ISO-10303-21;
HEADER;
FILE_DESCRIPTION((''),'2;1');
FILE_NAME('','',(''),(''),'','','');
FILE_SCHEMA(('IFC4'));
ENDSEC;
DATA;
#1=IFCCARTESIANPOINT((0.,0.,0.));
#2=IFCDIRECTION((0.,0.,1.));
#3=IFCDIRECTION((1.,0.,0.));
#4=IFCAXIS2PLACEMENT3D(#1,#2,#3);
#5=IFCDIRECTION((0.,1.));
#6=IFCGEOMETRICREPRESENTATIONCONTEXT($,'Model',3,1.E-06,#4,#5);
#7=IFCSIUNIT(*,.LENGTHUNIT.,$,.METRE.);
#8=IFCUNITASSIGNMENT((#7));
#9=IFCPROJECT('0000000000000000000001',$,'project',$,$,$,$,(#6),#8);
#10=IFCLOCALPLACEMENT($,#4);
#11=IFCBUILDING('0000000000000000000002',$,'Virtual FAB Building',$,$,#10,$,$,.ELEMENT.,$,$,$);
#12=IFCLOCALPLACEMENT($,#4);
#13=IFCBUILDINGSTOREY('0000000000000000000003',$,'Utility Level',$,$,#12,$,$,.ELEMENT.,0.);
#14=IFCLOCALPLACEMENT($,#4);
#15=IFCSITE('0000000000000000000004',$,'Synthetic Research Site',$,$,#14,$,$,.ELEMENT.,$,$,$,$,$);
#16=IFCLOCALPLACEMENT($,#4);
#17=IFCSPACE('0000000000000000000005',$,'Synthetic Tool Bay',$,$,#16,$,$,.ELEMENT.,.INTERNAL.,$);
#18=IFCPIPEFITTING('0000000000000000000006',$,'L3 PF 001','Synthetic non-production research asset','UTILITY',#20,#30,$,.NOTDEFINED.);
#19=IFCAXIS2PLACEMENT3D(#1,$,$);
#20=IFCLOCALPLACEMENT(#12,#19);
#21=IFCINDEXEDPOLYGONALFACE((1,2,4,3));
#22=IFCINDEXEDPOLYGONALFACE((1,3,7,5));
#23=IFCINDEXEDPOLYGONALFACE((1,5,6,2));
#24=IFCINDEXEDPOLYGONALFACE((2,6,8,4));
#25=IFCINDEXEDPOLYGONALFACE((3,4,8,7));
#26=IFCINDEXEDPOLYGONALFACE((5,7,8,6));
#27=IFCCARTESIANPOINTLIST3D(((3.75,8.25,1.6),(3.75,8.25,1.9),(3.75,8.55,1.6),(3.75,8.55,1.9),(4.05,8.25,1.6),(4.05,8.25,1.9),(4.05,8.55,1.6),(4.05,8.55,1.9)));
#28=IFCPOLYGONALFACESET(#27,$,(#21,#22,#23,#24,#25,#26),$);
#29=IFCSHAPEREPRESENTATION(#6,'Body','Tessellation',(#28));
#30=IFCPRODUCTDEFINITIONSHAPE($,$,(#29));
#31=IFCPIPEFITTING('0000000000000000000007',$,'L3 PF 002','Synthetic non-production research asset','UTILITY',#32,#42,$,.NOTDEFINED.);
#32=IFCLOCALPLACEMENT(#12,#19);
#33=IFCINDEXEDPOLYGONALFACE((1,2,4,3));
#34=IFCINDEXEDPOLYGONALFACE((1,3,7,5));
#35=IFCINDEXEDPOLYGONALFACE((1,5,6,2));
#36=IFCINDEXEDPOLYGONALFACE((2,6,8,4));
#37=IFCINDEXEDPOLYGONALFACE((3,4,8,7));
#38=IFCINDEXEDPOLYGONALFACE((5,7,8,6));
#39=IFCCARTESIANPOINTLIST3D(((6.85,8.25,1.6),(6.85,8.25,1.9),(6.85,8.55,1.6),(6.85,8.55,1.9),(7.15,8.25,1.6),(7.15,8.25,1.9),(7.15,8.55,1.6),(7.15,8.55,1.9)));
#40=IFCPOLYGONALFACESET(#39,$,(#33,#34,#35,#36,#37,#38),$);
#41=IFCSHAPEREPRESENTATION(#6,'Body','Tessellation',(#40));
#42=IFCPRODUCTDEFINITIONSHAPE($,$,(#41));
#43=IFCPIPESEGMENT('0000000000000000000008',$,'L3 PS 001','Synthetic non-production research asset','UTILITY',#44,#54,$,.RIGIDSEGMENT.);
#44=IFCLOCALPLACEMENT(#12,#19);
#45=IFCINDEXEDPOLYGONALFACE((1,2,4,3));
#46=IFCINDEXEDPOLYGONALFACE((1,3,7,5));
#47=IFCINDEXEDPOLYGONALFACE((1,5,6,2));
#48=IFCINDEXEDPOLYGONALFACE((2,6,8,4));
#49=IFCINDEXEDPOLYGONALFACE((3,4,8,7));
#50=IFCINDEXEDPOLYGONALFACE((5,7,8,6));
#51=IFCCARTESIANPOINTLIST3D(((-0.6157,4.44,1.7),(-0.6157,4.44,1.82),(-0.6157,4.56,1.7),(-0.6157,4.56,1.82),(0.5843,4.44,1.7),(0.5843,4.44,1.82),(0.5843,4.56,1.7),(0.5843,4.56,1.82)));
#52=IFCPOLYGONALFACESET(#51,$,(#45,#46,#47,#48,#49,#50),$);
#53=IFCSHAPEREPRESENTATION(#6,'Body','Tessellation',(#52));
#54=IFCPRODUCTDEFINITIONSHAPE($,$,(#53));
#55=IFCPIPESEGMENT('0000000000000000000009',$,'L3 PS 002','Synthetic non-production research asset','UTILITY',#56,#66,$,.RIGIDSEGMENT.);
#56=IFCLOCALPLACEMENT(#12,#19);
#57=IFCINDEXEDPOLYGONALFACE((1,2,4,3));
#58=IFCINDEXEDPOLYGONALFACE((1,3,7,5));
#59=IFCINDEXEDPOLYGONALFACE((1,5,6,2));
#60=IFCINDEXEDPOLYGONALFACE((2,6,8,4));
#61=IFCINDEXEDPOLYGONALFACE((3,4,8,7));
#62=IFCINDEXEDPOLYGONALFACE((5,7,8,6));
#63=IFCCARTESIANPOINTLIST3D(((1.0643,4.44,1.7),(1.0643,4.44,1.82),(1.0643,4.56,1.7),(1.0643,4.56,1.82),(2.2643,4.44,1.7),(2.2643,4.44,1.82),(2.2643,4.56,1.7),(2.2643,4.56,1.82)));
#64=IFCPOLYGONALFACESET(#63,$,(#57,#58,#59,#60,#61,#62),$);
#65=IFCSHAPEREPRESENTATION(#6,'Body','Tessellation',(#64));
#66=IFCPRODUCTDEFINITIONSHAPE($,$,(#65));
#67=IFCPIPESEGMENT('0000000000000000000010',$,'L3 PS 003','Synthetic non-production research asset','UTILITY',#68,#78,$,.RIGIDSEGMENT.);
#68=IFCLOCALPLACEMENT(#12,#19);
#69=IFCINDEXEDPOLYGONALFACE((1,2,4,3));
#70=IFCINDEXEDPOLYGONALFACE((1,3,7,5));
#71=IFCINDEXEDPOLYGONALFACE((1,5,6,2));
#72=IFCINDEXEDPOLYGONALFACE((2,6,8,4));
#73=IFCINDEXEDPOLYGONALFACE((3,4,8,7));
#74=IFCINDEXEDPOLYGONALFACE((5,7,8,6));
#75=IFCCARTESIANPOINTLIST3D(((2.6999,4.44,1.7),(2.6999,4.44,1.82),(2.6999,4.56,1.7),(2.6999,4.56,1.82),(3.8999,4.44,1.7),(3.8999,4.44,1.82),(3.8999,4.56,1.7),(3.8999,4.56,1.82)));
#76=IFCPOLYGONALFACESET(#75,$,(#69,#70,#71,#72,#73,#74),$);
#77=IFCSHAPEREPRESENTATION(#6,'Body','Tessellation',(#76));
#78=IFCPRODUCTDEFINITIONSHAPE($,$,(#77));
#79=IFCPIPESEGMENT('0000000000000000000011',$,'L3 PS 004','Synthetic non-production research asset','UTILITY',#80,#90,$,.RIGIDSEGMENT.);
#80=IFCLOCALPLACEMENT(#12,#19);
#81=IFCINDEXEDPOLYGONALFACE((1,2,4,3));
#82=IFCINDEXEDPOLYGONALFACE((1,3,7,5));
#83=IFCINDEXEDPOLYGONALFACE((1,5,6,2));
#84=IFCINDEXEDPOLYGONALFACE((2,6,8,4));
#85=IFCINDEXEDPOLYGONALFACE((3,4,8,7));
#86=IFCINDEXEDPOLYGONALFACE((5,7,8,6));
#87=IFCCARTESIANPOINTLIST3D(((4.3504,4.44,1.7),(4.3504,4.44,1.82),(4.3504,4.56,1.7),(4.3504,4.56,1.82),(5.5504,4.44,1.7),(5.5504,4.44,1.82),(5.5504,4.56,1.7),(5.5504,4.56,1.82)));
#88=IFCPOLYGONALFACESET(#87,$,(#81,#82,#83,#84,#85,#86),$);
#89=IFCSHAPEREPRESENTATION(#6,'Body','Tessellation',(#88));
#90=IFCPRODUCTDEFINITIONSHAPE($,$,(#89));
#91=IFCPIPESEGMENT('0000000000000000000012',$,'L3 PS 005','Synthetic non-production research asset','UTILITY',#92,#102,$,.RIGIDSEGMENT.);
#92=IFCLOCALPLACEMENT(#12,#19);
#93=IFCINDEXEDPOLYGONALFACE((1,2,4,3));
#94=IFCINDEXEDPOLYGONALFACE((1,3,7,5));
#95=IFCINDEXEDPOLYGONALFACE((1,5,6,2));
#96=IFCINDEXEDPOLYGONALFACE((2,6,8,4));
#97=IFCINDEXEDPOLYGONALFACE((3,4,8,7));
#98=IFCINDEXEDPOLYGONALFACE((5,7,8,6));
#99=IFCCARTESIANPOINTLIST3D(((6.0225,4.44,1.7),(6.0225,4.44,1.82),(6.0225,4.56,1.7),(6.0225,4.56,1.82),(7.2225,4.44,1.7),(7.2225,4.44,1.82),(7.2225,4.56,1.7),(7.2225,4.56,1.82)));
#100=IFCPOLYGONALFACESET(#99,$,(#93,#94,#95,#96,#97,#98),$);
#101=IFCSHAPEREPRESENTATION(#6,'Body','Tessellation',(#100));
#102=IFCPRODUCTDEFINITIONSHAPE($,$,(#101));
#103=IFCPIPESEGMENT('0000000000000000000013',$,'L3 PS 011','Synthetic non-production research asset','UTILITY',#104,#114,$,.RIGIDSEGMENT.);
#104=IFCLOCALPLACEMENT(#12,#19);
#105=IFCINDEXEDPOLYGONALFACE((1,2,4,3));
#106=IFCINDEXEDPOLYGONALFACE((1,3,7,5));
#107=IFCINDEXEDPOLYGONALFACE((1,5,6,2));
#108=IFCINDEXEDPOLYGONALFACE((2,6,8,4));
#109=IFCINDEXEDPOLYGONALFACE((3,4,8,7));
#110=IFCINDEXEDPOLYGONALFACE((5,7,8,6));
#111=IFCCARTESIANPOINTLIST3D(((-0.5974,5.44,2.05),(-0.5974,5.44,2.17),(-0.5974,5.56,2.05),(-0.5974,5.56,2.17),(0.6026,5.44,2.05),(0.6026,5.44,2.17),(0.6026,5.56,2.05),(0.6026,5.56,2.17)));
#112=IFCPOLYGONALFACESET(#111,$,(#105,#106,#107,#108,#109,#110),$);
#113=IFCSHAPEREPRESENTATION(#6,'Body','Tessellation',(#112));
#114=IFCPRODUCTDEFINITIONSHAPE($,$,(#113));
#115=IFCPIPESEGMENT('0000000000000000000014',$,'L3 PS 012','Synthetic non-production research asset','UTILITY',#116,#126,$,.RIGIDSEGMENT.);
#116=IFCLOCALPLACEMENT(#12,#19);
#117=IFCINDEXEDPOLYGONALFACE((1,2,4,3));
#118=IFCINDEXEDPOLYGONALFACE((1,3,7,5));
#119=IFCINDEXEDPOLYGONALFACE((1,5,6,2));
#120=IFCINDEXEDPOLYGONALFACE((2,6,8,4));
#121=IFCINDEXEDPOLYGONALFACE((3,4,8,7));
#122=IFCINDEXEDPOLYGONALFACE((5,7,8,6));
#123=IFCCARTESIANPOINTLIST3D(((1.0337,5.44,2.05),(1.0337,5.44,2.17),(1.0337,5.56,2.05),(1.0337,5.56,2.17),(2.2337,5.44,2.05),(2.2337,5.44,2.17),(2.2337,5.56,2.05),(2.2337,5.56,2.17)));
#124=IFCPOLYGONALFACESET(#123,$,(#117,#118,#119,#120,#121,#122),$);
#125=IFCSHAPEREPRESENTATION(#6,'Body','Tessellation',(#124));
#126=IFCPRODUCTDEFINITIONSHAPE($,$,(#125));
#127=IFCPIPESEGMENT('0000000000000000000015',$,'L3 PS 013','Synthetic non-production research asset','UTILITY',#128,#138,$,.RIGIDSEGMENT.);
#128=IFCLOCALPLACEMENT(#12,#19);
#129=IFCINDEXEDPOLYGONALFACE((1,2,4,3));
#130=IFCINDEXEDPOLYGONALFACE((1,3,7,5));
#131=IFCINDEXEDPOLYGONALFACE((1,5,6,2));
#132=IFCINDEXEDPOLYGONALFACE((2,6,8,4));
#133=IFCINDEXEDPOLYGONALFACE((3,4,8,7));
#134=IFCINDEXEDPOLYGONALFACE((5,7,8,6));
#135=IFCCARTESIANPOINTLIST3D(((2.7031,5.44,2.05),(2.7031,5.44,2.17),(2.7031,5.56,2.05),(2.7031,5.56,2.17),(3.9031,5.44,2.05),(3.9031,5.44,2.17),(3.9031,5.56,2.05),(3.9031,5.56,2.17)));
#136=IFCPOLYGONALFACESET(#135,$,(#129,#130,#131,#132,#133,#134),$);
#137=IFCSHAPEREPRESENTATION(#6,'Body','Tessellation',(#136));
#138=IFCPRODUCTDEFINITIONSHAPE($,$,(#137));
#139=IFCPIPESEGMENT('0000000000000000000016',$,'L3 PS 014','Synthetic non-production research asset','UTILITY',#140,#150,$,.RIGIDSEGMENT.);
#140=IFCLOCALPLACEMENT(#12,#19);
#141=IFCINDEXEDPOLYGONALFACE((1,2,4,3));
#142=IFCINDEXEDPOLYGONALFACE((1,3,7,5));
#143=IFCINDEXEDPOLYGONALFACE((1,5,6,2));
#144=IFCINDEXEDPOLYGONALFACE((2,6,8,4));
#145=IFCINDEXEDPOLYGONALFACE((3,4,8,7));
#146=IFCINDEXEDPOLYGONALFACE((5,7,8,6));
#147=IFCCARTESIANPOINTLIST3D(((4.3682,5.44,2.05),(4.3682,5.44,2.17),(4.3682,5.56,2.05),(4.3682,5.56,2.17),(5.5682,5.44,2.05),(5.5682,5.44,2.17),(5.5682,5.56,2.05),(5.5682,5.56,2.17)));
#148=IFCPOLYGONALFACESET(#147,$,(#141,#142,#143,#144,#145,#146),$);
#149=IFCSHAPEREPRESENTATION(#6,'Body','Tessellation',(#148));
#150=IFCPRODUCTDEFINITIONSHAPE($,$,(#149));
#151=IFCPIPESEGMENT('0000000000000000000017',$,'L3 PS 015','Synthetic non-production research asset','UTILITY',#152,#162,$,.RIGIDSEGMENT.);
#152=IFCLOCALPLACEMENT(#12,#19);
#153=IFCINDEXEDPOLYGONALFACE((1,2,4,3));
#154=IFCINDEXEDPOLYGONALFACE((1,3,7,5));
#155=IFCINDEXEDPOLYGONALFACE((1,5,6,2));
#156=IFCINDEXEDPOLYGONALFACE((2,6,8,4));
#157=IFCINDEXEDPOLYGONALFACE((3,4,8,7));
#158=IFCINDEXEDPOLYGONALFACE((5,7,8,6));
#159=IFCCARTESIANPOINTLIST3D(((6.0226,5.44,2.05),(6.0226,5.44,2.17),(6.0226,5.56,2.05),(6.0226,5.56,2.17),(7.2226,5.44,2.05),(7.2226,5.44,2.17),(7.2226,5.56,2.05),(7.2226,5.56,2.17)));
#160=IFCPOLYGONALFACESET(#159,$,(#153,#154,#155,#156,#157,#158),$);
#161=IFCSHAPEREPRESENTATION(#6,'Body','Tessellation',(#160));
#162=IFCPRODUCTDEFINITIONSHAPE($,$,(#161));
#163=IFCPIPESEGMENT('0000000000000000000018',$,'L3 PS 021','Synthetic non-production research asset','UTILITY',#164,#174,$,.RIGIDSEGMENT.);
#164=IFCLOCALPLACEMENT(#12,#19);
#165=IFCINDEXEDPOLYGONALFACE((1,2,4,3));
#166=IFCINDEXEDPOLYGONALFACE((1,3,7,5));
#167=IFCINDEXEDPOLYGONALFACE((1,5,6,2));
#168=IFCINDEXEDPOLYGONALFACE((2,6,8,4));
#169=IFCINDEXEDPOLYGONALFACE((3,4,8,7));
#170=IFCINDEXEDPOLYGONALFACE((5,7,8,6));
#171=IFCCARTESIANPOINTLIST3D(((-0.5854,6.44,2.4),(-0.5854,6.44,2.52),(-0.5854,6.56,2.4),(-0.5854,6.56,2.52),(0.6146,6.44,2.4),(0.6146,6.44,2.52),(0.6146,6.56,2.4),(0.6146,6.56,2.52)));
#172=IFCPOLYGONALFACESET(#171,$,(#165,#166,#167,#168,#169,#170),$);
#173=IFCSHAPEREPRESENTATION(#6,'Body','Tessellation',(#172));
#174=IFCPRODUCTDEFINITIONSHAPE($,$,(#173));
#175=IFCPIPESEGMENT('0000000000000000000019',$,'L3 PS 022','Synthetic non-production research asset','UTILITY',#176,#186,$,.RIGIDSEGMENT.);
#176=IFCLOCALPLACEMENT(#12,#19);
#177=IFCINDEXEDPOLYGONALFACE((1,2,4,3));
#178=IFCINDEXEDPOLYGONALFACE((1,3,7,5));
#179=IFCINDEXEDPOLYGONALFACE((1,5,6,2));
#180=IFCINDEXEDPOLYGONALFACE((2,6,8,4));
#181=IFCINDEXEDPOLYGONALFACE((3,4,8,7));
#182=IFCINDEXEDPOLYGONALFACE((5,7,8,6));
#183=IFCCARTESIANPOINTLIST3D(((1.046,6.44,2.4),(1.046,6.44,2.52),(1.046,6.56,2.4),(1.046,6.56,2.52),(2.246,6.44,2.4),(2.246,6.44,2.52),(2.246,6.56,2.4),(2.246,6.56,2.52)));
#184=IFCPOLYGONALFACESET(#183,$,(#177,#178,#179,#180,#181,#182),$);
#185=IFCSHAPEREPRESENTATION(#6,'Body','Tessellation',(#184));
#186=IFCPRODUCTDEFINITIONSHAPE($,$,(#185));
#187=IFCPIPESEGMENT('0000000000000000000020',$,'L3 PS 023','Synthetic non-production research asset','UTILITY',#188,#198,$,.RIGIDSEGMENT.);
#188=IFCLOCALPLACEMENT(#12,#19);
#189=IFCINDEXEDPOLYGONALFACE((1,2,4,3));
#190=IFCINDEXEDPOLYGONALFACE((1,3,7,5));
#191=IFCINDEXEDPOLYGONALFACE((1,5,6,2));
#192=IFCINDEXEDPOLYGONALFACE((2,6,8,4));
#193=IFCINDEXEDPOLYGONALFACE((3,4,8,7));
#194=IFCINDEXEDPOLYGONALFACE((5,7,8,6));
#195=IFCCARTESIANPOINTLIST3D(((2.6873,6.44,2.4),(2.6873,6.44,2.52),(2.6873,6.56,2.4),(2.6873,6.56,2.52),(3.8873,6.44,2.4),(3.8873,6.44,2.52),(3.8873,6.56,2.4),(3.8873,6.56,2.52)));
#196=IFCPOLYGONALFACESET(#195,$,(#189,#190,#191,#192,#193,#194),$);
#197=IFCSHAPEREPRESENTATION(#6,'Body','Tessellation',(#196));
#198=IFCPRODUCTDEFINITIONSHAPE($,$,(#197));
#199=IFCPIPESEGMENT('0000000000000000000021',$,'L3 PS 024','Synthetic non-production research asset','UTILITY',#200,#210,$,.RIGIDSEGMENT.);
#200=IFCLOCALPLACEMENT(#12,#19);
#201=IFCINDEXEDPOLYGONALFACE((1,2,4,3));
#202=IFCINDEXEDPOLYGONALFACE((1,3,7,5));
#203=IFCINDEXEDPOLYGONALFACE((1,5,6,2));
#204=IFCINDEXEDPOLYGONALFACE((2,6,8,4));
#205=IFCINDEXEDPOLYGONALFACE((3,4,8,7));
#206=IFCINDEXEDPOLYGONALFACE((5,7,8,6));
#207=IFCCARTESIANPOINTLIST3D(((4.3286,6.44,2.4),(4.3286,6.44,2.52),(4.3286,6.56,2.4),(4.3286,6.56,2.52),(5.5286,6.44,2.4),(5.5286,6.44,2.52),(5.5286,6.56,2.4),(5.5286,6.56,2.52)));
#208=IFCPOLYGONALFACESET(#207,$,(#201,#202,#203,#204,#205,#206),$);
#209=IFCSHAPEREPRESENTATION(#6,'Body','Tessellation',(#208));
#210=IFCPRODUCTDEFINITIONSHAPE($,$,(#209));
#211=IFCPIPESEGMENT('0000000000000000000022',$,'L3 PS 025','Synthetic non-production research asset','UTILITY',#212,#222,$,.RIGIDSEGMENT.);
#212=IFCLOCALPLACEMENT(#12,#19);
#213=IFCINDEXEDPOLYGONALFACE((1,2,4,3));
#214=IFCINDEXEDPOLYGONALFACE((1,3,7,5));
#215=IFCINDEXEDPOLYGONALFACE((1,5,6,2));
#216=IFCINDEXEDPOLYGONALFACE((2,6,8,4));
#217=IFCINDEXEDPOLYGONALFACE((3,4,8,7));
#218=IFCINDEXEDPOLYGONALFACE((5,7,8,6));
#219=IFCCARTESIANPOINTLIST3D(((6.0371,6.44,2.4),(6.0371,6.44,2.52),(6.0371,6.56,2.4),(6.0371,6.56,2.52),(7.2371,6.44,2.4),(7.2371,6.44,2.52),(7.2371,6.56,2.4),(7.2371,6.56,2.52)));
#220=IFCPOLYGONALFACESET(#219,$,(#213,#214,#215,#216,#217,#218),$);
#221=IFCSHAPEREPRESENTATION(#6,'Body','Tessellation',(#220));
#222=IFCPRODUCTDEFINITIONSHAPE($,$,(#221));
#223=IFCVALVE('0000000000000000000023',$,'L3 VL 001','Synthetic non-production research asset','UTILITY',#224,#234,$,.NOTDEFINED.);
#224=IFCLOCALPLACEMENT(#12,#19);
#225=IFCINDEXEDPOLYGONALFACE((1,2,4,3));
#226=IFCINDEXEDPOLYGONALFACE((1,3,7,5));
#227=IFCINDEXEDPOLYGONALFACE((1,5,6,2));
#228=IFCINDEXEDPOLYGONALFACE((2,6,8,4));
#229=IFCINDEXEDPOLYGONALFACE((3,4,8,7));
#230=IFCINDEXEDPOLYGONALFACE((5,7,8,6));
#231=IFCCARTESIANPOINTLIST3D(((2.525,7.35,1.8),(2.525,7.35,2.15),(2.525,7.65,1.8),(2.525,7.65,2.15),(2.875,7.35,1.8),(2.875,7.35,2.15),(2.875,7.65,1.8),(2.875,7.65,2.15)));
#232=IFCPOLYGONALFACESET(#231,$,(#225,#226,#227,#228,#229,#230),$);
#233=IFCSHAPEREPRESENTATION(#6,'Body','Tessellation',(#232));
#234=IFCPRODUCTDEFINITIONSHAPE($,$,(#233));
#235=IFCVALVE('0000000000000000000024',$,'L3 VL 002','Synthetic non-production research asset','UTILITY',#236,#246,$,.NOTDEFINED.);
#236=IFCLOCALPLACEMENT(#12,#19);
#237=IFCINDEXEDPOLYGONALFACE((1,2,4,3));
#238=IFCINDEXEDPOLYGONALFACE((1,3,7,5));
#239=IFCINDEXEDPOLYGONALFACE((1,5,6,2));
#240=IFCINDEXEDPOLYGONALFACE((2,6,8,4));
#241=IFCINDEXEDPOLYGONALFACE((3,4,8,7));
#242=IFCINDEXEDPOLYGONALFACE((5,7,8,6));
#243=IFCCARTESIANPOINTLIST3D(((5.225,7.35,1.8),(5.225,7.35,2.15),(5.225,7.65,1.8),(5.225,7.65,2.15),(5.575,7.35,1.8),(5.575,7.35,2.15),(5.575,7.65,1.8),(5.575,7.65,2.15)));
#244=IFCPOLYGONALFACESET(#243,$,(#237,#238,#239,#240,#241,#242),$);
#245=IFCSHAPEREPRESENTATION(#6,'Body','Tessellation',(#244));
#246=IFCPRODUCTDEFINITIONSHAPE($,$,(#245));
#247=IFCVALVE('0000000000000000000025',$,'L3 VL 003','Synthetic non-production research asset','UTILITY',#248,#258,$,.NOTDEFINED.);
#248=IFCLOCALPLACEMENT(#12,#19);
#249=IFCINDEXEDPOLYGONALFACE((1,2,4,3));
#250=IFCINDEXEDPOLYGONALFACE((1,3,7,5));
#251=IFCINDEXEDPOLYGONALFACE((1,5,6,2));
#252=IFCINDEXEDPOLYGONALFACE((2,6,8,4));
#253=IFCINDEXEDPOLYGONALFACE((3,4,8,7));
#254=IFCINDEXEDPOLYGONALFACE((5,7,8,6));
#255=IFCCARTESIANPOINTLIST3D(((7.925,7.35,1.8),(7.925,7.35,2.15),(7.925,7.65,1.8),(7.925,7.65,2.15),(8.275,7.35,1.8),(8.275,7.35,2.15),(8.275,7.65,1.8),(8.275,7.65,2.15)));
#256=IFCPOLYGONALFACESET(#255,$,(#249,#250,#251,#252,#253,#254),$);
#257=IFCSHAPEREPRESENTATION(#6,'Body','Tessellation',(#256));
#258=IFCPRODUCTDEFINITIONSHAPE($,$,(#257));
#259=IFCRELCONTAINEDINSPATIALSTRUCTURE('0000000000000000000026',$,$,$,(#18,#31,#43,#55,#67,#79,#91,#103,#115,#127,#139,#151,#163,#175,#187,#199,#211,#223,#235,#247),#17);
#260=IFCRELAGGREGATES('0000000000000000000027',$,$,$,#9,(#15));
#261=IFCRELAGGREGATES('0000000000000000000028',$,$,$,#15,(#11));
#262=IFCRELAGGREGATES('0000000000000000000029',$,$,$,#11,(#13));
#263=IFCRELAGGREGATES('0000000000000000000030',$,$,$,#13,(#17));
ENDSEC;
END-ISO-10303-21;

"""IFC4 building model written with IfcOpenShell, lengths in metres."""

from ifc_helpers import new_model, si_unit, direction, frame, origin_with_axes, origin_2d_with_axis, place, context, project, spatial, rectangle, extrude, element, save


model = new_model("IFC4")

# Units and contexts
model_context = context("Model", 3, precision=1e-06, world=origin_with_axes(), true_north=direction((0.0, 1.0)))
ifc_project = project(units=[si_unit("LENGTHUNIT", "METRE")], contexts=[model_context])

# Site, building, storey, space
site_placement = place(None, origin_with_axes())
site = spatial("IfcSite", under=ifc_project, at=site_placement, Name="Synthetic Research Site", CompositionType="ELEMENT")
building_placement = place(None, origin_with_axes())
building = spatial("IfcBuilding", under=site, at=building_placement, Name="Virtual FAB Building", CompositionType="ELEMENT")
storey_placement = place(None, origin_with_axes())
storey = spatial("IfcBuildingStorey", under=building, at=storey_placement, Name="Utility Level", CompositionType="ELEMENT", Elevation=0.0)
space_placement = place(None, origin_with_axes())
space = spatial("IfcSpace", under=storey, at=space_placement, Name="Synthetic Tool Bay", CompositionType="ELEMENT", PredefinedType="INTERNAL")

# Pipe fittings
for number, where, z_axis, x_axis, name in (
    (1, (3.9, 8.4, 1.6), (0.0, 0.0, 1.0), (1.0, 0.0, 0.0), "L3 PF 001"),
    (2, (7.0, 8.4, 1.6), (0.0, 0.0, 1.0), (1.0, 0.0, 0.0), "L3 PF 002"),
):
    element("IfcPipeFitting", number, at=place(None, frame(where, z_axis=z_axis, x_axis=x_axis)), inside=space, Name=name, Description="Synthetic non-production research asset", ObjectType="UTILITY", PredefinedType="NOTDEFINED", context=model_context, shape_type="SweptSolid", body=[
        extrude(rectangle(XDim=0.3, YDim=0.3, at=origin_2d_with_axis()), origin_with_axes(), (0.0, 0.0, 1.0), 0.3),
    ])

# Pipe segments
for number, where, z_axis, x_axis, name in (
    (3, (-0.0157, 4.5, 1.7), (0.0, 0.0, 1.0), (1.0, 0.0, 0.0), "L3 PS 001"),
    (4, (1.6643, 4.5, 1.7), (0.0, 0.0, 1.0), (1.0, 0.0, 0.0), "L3 PS 002"),
    (5, (3.2999, 4.5, 1.7), (0.0, 0.0, 1.0), (1.0, 0.0, 0.0), "L3 PS 003"),
    (6, (4.9504, 4.5, 1.7), (0.0, 0.0, 1.0), (1.0, 0.0, 0.0), "L3 PS 004"),
    (7, (6.6225, 4.5, 1.7), (0.0, 0.0, 1.0), (1.0, 0.0, 0.0), "L3 PS 005"),
    (8, (0.0026, 5.5, 2.05), (0.0, 0.0, 1.0), (1.0, 0.0, 0.0), "L3 PS 011"),
    (9, (1.6337, 5.5, 2.05), (0.0, 0.0, 1.0), (1.0, 0.0, 0.0), "L3 PS 012"),
    (10, (3.3031, 5.5, 2.05), (0.0, 0.0, 1.0), (1.0, 0.0, 0.0), "L3 PS 013"),
    (11, (4.9682, 5.5, 2.05), (0.0, 0.0, 1.0), (1.0, 0.0, 0.0), "L3 PS 014"),
    (12, (6.6226, 5.5, 2.05), (0.0, 0.0, 1.0), (1.0, 0.0, 0.0), "L3 PS 015"),
    (13, (0.0146, 6.5, 2.4), (0.0, 0.0, 1.0), (1.0, 0.0, 0.0), "L3 PS 021"),
    (14, (1.646, 6.5, 2.4), (0.0, 0.0, 1.0), (1.0, 0.0, 0.0), "L3 PS 022"),
    (15, (3.2873, 6.5, 2.4), (0.0, 0.0, 1.0), (1.0, 0.0, 0.0), "L3 PS 023"),
    (16, (4.9286, 6.5, 2.4), (0.0, 0.0, 1.0), (1.0, 0.0, 0.0), "L3 PS 024"),
    (17, (6.6371, 6.5, 2.4), (0.0, 0.0, 1.0), (1.0, 0.0, 0.0), "L3 PS 025"),
):
    element("IfcPipeSegment", number, at=place(None, frame(where, z_axis=z_axis, x_axis=x_axis)), inside=space, Name=name, Description="Synthetic non-production research asset", ObjectType="UTILITY", PredefinedType="RIGIDSEGMENT", context=model_context, shape_type="SweptSolid", body=[
        extrude(rectangle(XDim=1.2, YDim=0.12, at=origin_2d_with_axis()), origin_with_axes(), (0.0, 0.0, 1.0), 0.12),
    ])

# Valves
for number, where, z_axis, x_axis, name in (
    (18, (2.7, 7.5, 1.8), (0.0, 0.0, 1.0), (1.0, 0.0, 0.0), "L3 VL 001"),
    (19, (5.4, 7.5, 1.8), (0.0, 0.0, 1.0), (1.0, 0.0, 0.0), "L3 VL 002"),
    (20, (8.1, 7.5, 1.8), (0.0, 0.0, 1.0), (1.0, 0.0, 0.0), "L3 VL 003"),
):
    element("IfcValve", number, at=place(None, frame(where, z_axis=z_axis, x_axis=x_axis)), inside=space, Name=name, Description="Synthetic non-production research asset", ObjectType="UTILITY", PredefinedType="NOTDEFINED", context=model_context, shape_type="SweptSolid", body=[
        extrude(rectangle(XDim=0.35, YDim=0.3, at=origin_2d_with_axis()), origin_with_axes(), (0.0, 0.0, 1.0), 0.35),
    ])

save(model, "model.ifc")
